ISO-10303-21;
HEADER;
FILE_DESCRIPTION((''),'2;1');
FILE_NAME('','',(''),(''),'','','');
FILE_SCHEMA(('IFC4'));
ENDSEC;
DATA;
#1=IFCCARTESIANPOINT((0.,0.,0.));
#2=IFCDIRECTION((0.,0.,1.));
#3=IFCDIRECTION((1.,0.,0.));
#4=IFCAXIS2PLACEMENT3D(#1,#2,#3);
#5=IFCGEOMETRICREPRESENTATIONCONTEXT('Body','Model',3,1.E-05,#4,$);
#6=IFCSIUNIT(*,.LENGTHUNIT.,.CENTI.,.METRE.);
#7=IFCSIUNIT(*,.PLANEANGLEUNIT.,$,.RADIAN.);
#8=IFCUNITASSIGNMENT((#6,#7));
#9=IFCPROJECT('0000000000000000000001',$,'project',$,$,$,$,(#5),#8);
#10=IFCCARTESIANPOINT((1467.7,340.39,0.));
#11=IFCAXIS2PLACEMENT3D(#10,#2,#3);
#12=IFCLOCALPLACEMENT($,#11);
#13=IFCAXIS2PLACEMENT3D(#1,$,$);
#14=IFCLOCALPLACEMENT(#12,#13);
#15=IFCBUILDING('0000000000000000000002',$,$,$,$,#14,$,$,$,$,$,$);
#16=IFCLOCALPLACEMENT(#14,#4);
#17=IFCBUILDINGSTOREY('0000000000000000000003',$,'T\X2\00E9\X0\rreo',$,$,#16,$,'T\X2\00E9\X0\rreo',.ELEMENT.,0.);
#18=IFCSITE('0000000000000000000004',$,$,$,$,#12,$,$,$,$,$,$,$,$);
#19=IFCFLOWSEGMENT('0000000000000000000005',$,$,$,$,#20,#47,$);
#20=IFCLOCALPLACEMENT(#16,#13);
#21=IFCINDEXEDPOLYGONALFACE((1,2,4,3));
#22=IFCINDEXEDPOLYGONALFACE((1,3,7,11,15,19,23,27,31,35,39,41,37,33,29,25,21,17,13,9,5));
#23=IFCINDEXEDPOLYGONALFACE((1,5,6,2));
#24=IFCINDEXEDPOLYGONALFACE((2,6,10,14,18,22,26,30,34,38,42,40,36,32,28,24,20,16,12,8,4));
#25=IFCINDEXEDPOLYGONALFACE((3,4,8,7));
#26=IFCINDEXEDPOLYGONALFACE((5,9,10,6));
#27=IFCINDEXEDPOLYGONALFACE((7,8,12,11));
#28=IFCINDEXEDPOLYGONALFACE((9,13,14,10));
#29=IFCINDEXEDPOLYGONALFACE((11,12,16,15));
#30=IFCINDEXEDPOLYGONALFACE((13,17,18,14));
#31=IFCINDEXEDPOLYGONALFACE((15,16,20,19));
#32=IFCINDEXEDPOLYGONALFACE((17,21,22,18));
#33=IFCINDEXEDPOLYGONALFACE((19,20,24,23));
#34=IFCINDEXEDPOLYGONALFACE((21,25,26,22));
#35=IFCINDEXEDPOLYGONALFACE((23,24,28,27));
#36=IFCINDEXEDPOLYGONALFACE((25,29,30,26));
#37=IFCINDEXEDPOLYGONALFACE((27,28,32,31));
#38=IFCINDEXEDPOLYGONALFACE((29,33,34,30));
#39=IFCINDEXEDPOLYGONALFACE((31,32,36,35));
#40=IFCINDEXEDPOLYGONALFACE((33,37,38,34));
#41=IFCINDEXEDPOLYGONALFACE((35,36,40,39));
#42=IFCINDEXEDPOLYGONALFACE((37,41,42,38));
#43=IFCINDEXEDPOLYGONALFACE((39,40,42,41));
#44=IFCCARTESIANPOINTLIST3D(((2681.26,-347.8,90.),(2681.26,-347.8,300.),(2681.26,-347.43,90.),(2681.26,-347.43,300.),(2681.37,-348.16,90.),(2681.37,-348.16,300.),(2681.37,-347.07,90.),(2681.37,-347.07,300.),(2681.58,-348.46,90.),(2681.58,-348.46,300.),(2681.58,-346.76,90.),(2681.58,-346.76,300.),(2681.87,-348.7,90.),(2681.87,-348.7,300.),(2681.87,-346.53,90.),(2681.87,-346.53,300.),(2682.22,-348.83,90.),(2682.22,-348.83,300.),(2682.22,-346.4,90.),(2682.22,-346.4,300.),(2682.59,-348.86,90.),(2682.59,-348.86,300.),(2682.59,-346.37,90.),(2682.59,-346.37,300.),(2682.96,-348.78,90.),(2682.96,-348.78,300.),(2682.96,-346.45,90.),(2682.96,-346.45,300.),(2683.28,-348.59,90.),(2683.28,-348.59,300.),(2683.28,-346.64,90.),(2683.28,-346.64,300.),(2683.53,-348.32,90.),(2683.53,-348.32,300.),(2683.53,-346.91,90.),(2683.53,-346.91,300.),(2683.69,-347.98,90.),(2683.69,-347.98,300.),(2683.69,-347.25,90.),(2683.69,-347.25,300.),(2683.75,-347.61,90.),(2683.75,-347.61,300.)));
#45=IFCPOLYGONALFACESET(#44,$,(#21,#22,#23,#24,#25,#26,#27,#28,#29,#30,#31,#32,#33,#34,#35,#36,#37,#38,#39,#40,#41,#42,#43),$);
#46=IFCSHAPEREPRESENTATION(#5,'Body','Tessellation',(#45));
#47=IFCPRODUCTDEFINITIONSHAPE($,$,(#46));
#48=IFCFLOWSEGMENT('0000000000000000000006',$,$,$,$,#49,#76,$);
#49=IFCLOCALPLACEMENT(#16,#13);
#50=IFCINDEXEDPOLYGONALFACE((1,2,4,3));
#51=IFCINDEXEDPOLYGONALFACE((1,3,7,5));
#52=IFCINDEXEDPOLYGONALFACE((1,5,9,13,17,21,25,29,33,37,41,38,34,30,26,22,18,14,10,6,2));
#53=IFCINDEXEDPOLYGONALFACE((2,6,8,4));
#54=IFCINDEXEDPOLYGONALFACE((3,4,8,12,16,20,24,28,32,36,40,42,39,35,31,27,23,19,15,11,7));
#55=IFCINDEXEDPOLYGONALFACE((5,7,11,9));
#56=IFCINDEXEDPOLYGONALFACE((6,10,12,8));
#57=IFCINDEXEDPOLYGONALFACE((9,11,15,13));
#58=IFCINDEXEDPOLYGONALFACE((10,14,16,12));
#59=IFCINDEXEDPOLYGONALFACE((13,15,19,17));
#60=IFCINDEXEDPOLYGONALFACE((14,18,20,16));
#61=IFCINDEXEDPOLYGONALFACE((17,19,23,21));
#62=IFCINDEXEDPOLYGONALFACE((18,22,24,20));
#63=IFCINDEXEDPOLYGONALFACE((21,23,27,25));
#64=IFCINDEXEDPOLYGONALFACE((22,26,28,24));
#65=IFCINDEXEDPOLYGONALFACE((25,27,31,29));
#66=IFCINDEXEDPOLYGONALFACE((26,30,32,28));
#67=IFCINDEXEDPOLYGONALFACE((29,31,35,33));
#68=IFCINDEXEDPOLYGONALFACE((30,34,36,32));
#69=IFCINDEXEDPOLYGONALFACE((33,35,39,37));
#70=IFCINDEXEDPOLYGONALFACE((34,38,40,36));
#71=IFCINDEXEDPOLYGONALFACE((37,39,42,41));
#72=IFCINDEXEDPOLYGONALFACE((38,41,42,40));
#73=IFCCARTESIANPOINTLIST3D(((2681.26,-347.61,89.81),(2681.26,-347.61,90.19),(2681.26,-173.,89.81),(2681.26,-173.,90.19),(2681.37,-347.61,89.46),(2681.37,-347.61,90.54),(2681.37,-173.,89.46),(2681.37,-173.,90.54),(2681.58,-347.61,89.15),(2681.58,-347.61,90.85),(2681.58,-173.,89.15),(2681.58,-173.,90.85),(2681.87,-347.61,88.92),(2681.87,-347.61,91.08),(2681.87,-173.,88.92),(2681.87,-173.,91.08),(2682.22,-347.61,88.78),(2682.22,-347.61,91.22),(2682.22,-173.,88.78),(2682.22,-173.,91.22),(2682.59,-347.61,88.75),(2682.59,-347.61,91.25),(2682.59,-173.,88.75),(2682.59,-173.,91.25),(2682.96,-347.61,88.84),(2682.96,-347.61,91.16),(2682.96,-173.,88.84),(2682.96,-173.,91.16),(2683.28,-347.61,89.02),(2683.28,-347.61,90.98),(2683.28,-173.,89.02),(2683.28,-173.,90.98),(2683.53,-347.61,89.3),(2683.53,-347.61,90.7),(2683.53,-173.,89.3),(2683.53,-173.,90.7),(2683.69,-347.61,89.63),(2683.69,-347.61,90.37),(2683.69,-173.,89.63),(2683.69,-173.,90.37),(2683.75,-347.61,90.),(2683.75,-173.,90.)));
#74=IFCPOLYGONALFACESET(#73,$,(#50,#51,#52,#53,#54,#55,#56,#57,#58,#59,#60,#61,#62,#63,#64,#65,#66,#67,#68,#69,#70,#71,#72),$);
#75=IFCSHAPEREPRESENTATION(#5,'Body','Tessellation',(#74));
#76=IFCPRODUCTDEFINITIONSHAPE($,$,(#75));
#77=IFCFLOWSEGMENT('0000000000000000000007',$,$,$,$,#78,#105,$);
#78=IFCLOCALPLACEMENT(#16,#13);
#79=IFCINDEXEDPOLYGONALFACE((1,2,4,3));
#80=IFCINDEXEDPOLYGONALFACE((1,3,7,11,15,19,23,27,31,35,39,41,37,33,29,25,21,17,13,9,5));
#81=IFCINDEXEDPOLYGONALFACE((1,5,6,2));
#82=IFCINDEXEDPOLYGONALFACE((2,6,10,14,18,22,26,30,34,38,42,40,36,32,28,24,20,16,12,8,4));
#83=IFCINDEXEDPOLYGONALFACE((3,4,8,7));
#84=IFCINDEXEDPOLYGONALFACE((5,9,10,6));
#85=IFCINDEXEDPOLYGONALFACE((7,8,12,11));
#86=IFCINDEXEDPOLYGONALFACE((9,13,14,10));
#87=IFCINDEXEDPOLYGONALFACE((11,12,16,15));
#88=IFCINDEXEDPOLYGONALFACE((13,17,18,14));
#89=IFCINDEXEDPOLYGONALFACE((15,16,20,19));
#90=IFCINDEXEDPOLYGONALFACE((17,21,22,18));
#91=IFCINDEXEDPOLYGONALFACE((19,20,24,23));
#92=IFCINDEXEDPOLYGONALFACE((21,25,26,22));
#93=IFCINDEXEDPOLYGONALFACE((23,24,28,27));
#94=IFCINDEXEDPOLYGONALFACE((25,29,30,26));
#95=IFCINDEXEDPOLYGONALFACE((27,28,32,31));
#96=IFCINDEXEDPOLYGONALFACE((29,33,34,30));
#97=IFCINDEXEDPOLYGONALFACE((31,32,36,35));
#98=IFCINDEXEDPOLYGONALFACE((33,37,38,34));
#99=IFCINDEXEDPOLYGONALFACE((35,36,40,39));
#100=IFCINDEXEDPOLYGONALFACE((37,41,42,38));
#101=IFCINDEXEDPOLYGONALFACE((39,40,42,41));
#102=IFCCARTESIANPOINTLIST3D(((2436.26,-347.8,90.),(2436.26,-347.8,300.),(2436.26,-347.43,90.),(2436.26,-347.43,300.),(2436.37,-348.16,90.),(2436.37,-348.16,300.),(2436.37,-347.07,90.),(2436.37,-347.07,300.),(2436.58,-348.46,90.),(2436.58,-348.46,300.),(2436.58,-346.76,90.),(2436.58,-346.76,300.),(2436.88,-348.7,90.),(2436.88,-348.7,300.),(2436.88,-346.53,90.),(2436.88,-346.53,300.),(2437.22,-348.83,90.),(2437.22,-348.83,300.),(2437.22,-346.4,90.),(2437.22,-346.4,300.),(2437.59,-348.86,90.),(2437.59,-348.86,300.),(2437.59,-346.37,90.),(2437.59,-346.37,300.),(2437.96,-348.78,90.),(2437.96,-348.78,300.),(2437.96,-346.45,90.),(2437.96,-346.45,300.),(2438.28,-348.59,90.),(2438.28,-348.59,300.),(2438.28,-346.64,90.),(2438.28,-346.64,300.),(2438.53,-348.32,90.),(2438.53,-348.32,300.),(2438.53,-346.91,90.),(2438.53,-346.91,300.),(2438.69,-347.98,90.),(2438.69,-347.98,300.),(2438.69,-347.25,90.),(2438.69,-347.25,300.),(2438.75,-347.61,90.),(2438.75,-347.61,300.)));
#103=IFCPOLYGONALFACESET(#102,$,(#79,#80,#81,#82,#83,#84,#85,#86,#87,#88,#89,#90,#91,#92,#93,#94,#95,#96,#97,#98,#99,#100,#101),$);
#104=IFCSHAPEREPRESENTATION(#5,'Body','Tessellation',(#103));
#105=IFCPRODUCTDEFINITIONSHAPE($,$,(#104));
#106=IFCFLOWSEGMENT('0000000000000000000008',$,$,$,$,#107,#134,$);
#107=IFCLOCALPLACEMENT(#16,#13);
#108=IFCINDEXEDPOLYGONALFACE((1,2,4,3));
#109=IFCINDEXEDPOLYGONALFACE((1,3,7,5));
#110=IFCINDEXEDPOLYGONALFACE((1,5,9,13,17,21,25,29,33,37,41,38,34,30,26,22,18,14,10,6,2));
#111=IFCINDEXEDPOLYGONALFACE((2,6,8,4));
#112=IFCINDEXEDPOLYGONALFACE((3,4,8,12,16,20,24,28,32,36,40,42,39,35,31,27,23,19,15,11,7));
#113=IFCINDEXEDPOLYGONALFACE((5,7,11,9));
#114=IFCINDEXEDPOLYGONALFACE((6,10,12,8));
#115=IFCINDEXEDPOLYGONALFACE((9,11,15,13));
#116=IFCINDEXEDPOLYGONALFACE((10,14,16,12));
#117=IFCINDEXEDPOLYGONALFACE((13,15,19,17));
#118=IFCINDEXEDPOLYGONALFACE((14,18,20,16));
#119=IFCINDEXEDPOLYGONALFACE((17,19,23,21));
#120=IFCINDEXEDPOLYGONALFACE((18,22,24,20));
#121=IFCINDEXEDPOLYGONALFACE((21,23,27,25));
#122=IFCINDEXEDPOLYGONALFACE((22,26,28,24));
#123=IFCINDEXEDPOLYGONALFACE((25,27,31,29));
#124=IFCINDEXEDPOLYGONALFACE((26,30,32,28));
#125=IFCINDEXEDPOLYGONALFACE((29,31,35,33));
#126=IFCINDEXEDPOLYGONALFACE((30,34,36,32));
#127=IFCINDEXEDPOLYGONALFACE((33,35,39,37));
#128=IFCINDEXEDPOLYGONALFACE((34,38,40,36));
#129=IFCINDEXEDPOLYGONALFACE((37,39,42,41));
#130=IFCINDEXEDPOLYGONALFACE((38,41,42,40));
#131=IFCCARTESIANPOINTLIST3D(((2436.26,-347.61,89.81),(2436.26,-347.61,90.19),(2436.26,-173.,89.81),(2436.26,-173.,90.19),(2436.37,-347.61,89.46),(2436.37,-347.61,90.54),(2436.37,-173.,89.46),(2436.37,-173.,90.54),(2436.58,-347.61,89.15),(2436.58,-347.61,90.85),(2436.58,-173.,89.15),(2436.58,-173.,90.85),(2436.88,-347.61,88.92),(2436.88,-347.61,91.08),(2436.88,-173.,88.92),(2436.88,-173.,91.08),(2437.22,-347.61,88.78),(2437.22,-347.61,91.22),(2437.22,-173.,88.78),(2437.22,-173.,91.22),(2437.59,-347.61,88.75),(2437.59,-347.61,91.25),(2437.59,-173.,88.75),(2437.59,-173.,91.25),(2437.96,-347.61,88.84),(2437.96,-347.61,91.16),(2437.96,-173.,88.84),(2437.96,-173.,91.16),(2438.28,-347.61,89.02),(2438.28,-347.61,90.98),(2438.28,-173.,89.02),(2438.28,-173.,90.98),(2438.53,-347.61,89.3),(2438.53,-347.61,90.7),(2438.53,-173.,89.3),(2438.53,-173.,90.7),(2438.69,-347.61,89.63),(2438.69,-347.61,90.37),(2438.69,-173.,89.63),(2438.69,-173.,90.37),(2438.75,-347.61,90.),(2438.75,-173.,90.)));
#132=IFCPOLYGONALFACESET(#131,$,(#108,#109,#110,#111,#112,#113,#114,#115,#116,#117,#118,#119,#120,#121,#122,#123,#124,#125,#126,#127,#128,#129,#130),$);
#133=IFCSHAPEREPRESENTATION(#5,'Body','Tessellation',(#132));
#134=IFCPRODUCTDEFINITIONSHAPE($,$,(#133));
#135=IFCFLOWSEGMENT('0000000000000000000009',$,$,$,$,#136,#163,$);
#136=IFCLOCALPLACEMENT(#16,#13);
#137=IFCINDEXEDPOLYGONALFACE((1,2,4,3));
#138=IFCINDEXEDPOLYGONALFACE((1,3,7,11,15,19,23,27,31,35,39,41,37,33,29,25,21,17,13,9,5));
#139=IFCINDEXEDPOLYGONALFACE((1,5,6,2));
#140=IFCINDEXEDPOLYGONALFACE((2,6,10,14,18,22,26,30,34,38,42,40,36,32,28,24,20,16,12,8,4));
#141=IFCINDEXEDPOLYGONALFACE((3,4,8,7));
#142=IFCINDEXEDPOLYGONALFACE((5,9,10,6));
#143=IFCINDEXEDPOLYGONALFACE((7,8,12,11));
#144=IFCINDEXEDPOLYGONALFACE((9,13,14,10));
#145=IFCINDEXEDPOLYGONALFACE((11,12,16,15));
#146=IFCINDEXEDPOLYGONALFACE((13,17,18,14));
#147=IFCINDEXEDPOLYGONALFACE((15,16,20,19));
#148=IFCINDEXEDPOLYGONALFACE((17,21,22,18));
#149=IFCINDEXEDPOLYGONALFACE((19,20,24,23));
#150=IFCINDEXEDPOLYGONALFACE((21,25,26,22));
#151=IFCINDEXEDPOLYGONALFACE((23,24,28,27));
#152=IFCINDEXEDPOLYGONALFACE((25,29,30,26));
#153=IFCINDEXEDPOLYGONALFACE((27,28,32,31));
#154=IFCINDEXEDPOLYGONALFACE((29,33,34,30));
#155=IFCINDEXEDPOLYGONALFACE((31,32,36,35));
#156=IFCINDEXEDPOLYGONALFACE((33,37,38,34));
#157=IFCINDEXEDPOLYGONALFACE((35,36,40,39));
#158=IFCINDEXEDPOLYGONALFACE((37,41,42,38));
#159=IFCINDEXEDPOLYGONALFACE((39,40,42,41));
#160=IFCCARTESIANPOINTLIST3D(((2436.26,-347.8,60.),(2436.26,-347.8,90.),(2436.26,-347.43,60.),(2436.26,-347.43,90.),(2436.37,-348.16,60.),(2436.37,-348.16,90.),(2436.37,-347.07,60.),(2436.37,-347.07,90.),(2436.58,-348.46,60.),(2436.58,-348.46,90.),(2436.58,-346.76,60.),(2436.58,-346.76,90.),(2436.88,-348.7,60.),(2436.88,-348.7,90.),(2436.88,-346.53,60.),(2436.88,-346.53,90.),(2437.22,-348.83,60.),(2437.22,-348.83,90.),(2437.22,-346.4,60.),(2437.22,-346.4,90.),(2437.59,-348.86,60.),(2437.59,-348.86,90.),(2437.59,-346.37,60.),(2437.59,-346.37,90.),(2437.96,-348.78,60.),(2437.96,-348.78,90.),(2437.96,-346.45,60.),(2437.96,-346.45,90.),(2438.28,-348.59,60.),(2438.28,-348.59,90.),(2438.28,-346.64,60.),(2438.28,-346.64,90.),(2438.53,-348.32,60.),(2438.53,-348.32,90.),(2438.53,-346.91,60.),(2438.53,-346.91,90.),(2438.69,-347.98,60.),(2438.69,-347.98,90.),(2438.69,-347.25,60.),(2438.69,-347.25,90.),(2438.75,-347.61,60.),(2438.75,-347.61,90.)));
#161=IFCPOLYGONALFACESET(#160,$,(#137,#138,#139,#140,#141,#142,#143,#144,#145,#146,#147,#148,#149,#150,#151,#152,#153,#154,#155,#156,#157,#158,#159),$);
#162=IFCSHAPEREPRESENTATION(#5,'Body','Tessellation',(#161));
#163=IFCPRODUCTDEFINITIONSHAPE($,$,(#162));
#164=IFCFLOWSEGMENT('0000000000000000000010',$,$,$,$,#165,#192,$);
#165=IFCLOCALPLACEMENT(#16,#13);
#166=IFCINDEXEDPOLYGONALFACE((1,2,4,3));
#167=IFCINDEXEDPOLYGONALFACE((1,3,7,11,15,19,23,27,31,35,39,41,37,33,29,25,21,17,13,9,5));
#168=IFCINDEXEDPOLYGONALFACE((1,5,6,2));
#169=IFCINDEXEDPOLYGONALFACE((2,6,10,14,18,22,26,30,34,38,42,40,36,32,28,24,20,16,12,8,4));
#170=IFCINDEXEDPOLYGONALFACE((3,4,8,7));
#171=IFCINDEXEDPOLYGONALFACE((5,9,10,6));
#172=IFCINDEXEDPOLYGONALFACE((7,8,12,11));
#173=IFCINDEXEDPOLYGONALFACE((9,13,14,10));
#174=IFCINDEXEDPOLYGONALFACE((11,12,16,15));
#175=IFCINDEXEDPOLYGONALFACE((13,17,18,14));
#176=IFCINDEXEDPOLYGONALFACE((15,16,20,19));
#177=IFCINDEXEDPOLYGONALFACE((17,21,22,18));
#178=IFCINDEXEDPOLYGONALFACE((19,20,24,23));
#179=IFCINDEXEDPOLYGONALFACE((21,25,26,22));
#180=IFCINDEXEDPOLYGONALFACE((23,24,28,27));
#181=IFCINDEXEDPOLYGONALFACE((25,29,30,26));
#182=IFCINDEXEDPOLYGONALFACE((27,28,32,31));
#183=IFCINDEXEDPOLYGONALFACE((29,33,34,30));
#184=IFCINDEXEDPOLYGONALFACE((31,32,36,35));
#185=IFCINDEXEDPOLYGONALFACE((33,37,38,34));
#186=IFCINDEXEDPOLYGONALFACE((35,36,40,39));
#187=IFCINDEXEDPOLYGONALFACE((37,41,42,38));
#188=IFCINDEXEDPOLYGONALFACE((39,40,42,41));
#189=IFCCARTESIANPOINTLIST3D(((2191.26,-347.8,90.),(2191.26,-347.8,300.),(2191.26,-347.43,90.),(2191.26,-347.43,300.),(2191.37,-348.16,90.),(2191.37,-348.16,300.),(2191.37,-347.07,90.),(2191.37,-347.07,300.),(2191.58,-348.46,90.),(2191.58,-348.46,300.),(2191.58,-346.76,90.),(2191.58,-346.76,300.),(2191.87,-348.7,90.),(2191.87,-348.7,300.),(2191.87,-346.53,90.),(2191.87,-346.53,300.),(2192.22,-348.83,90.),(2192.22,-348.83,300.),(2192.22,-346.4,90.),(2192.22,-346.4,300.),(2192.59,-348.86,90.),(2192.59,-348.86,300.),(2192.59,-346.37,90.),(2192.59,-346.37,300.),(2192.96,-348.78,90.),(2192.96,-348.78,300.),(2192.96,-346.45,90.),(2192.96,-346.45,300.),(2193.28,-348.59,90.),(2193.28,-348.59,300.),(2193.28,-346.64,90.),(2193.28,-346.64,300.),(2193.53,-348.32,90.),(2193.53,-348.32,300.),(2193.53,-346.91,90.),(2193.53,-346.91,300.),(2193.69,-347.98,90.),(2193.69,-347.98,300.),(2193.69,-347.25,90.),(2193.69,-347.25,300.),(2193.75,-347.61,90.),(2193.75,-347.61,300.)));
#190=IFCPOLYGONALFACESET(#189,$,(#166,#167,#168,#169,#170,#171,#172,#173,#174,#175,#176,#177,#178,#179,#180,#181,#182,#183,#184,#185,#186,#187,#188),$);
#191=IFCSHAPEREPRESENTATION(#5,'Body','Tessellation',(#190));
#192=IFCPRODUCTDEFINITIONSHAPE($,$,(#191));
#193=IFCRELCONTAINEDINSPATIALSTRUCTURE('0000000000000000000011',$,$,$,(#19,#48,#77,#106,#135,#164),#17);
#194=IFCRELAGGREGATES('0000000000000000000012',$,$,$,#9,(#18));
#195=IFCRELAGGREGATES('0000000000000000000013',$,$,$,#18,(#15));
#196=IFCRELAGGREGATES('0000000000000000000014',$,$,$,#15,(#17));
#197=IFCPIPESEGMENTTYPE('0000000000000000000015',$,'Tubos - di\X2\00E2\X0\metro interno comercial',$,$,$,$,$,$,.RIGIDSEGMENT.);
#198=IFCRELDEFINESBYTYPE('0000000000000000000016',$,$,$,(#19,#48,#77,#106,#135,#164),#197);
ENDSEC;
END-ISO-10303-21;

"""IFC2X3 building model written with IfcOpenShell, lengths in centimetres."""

from ifc_helpers import new_model, si_unit, frame, origin, origin_with_axes, origin_2d_with_axis, place, context, project, spatial, circle, extrude, type_object, element, save


model = new_model("IFC2X3")

# Units and contexts
model_context = context("Model", 3, precision=1e-05, world=origin_with_axes(), identifier="Body")
ifc_project = project(units=[si_unit("LENGTHUNIT", "METRE", prefix="CENTI"), si_unit("PLANEANGLEUNIT", "RADIAN")], contexts=[model_context])

# Site, building, storey
site_placement = place(None, frame((1467.7, 340.39, 0.0), z_axis=(0.0, 0.0, 1.0), x_axis=(1.0, 0.0, 0.0)))
site = spatial("IfcSite", under=ifc_project, at=site_placement)
building_placement = place(site_placement, origin())
building = spatial("IfcBuilding", under=site, at=building_placement)
storey_placement = place(building_placement, origin_with_axes())
storey = spatial("IfcBuildingStorey", under=building, at=storey_placement, Name="Térreo", LongName="Térreo", CompositionType="ELEMENT", Elevation=0.0)

# Flow segments
pipe_segment_type = type_object("IfcPipeSegmentType", Name="Tubos - diâmetro interno comercial", PredefinedType="RIGIDSEGMENT")
for number, where, z_axis, x_axis in (
    (1, (2682.5, -347.61, 300.0), (0.0, 0.0, 1.0), (1.0, 0.0, 0.0)),
):
    element("IfcFlowSegment", number, at=place(storey_placement, frame(where, z_axis=z_axis, x_axis=x_axis)), inside=storey, type_object=pipe_segment_type, context=model_context, shape_type="SolidModel", body=[
        extrude(circle(Radius=1.25, at=origin_2d_with_axis()), frame((0.0, 0.0, 0.0), z_axis=(0.0, 0.0, -1.0), x_axis=(1.0, 0.0, 0.0)), (0.0, 0.0, 1.0), 210.0),
    ])
flow_segment_1_placement = place(storey_placement, frame((2682.5, -260.31, 91.25), z_axis=(0.0, 0.0, 1.0), x_axis=(1.0, 0.0, 0.0)))
element("IfcFlowSegment", 2, at=flow_segment_1_placement, inside=storey, type_object=pipe_segment_type, context=model_context, shape_type="SolidModel", body=[
    extrude(circle(Radius=1.25, at=origin_2d_with_axis()), frame((0.0, -87.31, -1.25), z_axis=(0.0, 1.0, 0.0), x_axis=(1.0, 0.0, 0.0)), (0.0, 0.0, 1.0), 174.61),
])
flow_segment_2_placement = place(storey_placement, frame((2437.5, -347.61, 300.0), z_axis=(0.0, 0.0, 1.0), x_axis=(1.0, 0.0, 0.0)))
element("IfcFlowSegment", 3, at=flow_segment_2_placement, inside=storey, type_object=pipe_segment_type, context=model_context, shape_type="SolidModel", body=[
    extrude(circle(Radius=1.25, at=origin_2d_with_axis()), frame((0.0, 0.0, 0.0), z_axis=(0.0, 0.0, -1.0), x_axis=(1.0, 0.0, 0.0)), (0.0, 0.0, 1.0), 210.0),
])
flow_segment_3_placement = place(storey_placement, frame((2437.5, -260.31, 91.25), z_axis=(0.0, 0.0, 1.0), x_axis=(1.0, 0.0, 0.0)))
element("IfcFlowSegment", 4, at=flow_segment_3_placement, inside=storey, type_object=pipe_segment_type, context=model_context, shape_type="SolidModel", body=[
    extrude(circle(Radius=1.25, at=origin_2d_with_axis()), frame((0.0, -87.31, -1.25), z_axis=(0.0, 1.0, 0.0), x_axis=(1.0, 0.0, 0.0)), (0.0, 0.0, 1.0), 174.61),
])
flow_segment_4_placement = place(storey_placement, frame((2437.5, -347.61, 90.0), z_axis=(0.0, 0.0, 1.0), x_axis=(1.0, 0.0, 0.0)))
element("IfcFlowSegment", 5, at=flow_segment_4_placement, inside=storey, type_object=pipe_segment_type, context=model_context, shape_type="SolidModel", body=[
    extrude(circle(Radius=1.25, at=origin_2d_with_axis()), frame((0.0, 0.0, 0.0), z_axis=(0.0, 0.0, -1.0), x_axis=(1.0, 0.0, 0.0)), (0.0, 0.0, 1.0), 30.0),
])
flow_segment_5_placement = place(storey_placement, frame((2192.5, -347.61, 300.0), z_axis=(0.0, 0.0, 1.0), x_axis=(1.0, 0.0, 0.0)))
element("IfcFlowSegment", 6, at=flow_segment_5_placement, inside=storey, type_object=pipe_segment_type, context=model_context, shape_type="SolidModel", body=[
    extrude(circle(Radius=1.25, at=origin_2d_with_axis()), frame((0.0, 0.0, 0.0), z_axis=(0.0, 0.0, -1.0), x_axis=(1.0, 0.0, 0.0)), (0.0, 0.0, 1.0), 210.0),
])

save(model, "model.ifc")
